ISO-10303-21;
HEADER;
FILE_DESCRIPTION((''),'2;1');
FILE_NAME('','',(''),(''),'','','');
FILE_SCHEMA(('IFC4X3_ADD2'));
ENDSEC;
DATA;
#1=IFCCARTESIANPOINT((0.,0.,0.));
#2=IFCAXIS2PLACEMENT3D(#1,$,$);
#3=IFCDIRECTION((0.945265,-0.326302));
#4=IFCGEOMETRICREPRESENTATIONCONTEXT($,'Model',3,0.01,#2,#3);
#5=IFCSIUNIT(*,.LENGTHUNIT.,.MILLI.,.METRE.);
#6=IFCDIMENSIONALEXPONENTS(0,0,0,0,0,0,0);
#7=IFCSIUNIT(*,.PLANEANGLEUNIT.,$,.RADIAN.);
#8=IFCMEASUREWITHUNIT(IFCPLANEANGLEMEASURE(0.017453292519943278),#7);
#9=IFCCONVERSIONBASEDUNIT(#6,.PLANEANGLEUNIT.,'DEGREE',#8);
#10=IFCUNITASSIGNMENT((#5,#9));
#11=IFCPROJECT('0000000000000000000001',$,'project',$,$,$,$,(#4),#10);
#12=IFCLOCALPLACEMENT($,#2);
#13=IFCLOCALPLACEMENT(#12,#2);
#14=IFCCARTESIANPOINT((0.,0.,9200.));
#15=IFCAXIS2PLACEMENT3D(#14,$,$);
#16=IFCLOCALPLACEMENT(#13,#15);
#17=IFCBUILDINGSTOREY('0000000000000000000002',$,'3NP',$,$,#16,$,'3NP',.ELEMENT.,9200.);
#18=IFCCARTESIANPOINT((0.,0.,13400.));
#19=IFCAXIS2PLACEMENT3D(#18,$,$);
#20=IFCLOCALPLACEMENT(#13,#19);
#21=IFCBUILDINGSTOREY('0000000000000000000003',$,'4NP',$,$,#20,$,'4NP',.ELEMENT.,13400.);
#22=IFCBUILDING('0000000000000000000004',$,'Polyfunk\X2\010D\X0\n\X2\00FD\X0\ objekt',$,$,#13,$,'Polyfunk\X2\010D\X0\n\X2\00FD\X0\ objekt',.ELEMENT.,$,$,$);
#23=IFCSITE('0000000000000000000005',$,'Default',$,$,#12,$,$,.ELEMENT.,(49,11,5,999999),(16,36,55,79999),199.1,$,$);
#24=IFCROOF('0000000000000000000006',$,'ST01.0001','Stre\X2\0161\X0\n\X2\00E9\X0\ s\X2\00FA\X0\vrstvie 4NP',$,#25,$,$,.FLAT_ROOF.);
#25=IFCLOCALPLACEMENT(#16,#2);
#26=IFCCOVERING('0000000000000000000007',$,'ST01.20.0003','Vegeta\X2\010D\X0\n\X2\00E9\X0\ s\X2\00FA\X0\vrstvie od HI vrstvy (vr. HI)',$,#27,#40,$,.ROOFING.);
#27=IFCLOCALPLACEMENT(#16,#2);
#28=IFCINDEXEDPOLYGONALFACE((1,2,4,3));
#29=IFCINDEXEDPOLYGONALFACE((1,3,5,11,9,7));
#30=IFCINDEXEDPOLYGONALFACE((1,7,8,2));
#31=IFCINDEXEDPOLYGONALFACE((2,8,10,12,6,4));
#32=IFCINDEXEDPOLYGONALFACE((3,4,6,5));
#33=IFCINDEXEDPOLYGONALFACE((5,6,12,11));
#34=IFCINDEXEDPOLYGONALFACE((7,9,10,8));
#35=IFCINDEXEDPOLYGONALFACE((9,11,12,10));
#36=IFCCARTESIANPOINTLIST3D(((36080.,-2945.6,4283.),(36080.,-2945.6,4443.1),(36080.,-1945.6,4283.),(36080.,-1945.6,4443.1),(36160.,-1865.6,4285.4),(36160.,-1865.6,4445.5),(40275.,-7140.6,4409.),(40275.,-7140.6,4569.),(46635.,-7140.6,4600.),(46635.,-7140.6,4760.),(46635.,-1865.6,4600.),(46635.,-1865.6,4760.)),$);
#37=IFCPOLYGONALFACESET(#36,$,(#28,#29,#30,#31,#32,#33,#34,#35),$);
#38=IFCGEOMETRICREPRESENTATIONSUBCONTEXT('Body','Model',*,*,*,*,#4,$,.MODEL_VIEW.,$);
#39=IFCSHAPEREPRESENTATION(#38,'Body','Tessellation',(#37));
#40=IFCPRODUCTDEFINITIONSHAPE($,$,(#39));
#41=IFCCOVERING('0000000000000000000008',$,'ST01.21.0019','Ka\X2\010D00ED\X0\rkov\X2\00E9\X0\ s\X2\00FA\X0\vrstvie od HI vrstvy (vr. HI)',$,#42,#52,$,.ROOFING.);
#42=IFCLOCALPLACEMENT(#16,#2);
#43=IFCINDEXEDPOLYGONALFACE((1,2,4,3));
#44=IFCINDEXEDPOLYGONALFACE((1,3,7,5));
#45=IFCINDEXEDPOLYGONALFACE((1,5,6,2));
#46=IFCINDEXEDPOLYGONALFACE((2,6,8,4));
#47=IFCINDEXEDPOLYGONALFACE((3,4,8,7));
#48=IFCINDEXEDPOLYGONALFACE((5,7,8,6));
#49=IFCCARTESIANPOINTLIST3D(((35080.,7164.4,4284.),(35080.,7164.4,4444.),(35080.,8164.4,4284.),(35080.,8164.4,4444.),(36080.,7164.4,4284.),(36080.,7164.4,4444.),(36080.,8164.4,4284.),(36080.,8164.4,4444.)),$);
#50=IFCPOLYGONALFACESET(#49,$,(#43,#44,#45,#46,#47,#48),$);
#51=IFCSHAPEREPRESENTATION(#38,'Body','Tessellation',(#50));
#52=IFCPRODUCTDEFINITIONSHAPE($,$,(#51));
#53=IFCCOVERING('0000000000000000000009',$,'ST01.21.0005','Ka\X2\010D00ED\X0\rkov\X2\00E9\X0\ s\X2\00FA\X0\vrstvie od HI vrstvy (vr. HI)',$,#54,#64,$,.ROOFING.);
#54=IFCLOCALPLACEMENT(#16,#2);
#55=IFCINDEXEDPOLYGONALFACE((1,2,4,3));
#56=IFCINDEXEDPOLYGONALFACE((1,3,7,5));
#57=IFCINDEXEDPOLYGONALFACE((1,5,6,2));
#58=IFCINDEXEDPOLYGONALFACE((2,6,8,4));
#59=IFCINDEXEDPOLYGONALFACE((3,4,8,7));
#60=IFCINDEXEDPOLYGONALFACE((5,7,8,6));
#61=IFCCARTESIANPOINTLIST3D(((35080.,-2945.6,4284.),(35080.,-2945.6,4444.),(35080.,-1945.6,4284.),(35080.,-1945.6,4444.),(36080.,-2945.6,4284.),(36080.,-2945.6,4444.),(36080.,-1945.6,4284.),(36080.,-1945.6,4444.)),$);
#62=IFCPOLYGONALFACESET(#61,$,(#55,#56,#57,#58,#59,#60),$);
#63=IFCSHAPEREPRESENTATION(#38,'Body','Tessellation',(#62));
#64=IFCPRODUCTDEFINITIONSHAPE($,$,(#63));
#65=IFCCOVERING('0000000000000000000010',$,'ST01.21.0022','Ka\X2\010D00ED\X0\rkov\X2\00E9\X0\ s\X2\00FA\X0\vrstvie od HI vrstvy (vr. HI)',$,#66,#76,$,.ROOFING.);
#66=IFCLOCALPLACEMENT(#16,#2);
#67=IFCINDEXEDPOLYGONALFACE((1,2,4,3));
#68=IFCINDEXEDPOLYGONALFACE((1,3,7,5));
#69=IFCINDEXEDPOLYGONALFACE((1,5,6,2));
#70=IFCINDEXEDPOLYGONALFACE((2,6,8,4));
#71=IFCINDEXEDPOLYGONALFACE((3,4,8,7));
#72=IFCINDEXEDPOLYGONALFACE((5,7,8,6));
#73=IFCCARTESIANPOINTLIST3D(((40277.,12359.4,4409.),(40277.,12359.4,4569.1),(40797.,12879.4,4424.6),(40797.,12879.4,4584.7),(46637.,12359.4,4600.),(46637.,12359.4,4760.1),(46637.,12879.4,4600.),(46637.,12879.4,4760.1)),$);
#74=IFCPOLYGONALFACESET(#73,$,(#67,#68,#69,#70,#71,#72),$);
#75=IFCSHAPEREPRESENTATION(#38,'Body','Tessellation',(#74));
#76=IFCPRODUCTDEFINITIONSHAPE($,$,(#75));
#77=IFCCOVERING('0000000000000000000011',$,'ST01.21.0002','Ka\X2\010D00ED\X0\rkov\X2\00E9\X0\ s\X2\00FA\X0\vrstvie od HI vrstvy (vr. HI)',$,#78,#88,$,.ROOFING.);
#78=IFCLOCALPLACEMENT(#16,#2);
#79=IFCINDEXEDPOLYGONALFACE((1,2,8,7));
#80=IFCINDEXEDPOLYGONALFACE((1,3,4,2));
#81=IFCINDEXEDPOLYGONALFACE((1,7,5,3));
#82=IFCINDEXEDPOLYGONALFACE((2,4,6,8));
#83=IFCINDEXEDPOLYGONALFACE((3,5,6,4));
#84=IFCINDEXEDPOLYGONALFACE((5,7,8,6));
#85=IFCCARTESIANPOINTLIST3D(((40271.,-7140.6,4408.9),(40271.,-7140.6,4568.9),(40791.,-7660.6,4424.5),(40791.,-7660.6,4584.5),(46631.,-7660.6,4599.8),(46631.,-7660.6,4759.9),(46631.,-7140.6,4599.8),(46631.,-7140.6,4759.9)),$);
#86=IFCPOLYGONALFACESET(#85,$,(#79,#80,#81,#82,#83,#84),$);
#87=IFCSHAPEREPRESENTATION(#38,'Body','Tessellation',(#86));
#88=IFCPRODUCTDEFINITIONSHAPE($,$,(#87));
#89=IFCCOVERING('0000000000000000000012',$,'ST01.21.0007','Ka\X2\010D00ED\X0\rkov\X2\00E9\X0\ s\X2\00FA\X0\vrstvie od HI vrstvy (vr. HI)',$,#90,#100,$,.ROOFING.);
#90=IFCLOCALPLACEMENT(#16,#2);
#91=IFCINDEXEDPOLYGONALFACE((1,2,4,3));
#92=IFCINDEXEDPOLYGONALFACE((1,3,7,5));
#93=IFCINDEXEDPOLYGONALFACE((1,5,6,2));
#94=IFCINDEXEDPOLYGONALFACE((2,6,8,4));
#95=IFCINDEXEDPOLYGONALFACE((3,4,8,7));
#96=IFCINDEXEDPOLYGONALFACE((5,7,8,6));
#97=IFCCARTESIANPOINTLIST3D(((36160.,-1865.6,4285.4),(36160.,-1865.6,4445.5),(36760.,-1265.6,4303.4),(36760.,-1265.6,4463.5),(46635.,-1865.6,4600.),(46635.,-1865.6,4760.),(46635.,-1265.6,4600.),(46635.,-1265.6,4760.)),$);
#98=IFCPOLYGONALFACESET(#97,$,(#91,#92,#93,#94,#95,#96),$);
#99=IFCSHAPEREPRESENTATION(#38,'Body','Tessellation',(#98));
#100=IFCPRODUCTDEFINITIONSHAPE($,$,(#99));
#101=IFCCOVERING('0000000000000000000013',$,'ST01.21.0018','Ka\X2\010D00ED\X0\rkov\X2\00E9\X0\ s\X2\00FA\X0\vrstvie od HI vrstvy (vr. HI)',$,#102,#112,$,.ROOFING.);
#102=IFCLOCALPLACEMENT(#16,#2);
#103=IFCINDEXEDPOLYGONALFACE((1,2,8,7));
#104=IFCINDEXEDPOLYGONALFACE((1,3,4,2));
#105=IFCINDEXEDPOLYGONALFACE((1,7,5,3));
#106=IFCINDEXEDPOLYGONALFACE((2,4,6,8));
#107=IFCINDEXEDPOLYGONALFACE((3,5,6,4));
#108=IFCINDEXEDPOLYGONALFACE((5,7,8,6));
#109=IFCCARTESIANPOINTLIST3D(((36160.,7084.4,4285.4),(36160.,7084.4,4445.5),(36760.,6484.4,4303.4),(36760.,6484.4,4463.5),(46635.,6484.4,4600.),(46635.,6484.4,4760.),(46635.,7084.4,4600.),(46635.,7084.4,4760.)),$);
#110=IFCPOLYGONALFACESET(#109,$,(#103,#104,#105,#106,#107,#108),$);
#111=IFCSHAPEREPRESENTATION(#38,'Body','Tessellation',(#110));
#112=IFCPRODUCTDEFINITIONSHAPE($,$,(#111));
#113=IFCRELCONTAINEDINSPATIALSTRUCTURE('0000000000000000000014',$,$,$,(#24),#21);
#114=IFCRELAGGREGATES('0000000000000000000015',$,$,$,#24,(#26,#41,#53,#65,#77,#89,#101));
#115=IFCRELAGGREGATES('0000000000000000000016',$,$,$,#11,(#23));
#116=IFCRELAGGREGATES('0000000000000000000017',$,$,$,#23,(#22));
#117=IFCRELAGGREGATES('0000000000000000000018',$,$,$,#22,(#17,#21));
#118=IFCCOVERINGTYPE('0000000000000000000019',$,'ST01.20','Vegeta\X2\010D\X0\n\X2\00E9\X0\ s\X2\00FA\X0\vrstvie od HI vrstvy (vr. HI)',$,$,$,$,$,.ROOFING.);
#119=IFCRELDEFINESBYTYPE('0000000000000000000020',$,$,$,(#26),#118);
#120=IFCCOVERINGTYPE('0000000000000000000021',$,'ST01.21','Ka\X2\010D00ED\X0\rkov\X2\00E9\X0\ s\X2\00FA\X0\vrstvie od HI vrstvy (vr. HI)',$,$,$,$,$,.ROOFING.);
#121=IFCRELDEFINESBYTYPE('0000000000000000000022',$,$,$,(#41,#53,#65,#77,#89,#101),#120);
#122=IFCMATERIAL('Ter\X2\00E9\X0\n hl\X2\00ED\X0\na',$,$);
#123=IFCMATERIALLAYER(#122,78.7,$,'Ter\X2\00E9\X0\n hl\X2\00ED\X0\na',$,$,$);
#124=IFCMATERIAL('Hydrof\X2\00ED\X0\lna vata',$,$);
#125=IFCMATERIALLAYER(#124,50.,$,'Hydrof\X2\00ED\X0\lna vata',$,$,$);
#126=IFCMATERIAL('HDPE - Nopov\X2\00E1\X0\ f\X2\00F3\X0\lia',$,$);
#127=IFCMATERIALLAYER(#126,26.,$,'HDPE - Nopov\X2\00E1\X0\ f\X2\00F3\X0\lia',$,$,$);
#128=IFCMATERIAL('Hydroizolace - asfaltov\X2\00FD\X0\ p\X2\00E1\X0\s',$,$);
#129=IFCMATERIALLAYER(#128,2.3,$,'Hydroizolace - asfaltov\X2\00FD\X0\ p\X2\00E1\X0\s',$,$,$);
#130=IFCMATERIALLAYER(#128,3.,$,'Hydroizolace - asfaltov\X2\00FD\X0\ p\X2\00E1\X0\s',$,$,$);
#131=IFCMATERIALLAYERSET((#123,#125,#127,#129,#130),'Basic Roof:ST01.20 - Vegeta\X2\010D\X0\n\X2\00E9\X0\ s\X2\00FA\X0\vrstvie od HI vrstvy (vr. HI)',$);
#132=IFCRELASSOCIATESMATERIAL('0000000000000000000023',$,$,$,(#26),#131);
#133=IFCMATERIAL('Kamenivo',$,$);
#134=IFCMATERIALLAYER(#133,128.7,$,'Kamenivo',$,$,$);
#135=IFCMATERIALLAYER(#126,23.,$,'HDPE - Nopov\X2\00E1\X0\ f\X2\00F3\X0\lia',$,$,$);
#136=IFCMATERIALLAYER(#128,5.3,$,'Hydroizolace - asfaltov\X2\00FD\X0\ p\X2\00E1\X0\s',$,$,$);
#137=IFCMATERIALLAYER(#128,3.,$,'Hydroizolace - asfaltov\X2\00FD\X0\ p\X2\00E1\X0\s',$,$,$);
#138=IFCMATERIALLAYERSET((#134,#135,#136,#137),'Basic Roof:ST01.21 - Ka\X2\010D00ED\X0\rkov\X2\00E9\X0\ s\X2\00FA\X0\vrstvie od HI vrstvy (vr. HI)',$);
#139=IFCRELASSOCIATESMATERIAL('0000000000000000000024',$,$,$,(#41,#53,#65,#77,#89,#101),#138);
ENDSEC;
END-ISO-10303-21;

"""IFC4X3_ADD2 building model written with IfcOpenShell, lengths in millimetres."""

from ifc_helpers import new_model, entity, si_unit, converted_unit, direction, frame, frame_2d, origin, origin_2d_with_axis, place, context, subcontext, project, spatial, polyline, rectangle, outline, extrude, material, layer, layer_set, type_object, element, aggregate, save


model = new_model("IFC4X3_ADD2")

# Units and contexts
model_context = context("Model", 3, precision=0.01, world=origin(), true_north=direction((0.945265, -0.326302)))
body_context = subcontext(model_context, "Body", "Model", "MODEL_VIEW")
ifc_project = project(units=[si_unit("LENGTHUNIT", "METRE", prefix="MILLI"), converted_unit("PLANEANGLEUNIT", "DEGREE", entity("IfcPlaneAngleMeasure", 0.017453292519943278), si_unit("PLANEANGLEUNIT", "RADIAN"), dimensions=[0, 0, 0, 0, 0, 0, 0])], contexts=[model_context])

# Site, building, storey
site_placement = place(None, origin())
site = spatial("IfcSite", under=ifc_project, at=site_placement, Name="Default", CompositionType="ELEMENT", RefLatitude=(49, 11, 5, 999999), RefLongitude=(16, 36, 55, 79999), RefElevation=199.1)
building_placement = place(site_placement, origin())
building = spatial("IfcBuilding", under=site, at=building_placement, Name="Polyfunkčný objekt", LongName="Polyfunkčný objekt", CompositionType="ELEMENT")
storey_1_placement = place(building_placement, frame((0.0, 0.0, 9200.0)))
storey_1 = spatial("IfcBuildingStorey", under=building, at=storey_1_placement, Name="3NP", LongName="3NP", CompositionType="ELEMENT", Elevation=9200.0)

# Shared definitions
storey_2_placement = place(building_placement, frame((0.0, 0.0, 13400.0)))
storey_2 = spatial("IfcBuildingStorey", under=building, at=storey_2_placement, Name="4NP", LongName="4NP", CompositionType="ELEMENT", Elevation=13400.0)

# Roof, coverings
roof = element("IfcRoof", 1, inside=storey_2, Name="ST01.0001", Description="Strešné súvrstvie 4NP", PredefinedType="FLAT_ROOF")
ifc_material_1 = material(Name="Hydroizolace - asfaltový pás")
ifc_material_2 = material(Name="Terén hlína")
ifc_layer_1 = layer(ifc_material_2, 78.7, Name="Terén hlína")
ifc_material_3 = material(Name="Hydrofílna vata")
ifc_layer_2 = layer(ifc_material_3, 50.0, Name="Hydrofílna vata")
ifc_material_4 = material(Name="HDPE - Nopová fólia")
ifc_layer_3 = layer(ifc_material_4, 26.0, Name="HDPE - Nopová fólia")
ifc_layer_4 = layer(ifc_material_1, 2.3, Name="Hydroizolace - asfaltový pás")
ifc_layer_5 = layer(ifc_material_1, 3.0, Name="Hydroizolace - asfaltový pás")
ifc_layer_set_1 = layer_set([ifc_layer_1, ifc_layer_2, ifc_layer_3, ifc_layer_4, ifc_layer_5], Name="Basic Roof:ST01.20 - Vegetačné súvrstvie od HI vrstvy (vr. HI)")
covering_type_1 = type_object("IfcCoveringType", Name="ST01.20", Description="Vegetačné súvrstvie od HI vrstvy (vr. HI)", PredefinedType="ROOFING")
placement_1 = place(storey_2_placement, frame((36080.0, -7140.6, 83.0)))
covering_1_placement = place(placement_1, origin())
covering_1 = element("IfcCovering", 2, at=covering_1_placement, type_object=covering_type_1, material=ifc_layer_set_1, Name="ST01.20.0003", Description="Vegetačné súvrstvie od HI vrstvy (vr. HI)", PredefinedType="ROOFING", context=body_context, shape_type="SweptSolid", body=[
    extrude(outline(polyline([(-5279.9, 1557.5), (-1083.0, -2637.5), (5279.9, -2637.5), (5279.9, 2637.5), (-5199.8, 2637.5), (-5279.9, 2557.5), (-5279.9, 1557.5)])), frame((5277.5, 2637.5, 158.5), z_axis=(-0.030015, 0.0, 0.999549), x_axis=(0.999549, 0.0, 0.030015)), (0.030015, 0.0, 0.999549), 160.1),
])
ifc_material_5 = material(Name="Kamenivo")
ifc_layer_6 = layer(ifc_material_5, 128.7, Name="Kamenivo")
ifc_layer_7 = layer(ifc_material_4, 23.0, Name="HDPE - Nopová fólia")
ifc_layer_8 = layer(ifc_material_1, 5.3, Name="Hydroizolace - asfaltový pás")
ifc_layer_9 = layer(ifc_material_1, 3.0, Name="Hydroizolace - asfaltový pás")
ifc_layer_set_2 = layer_set([ifc_layer_6, ifc_layer_7, ifc_layer_8, ifc_layer_9], Name="Basic Roof:ST01.21 - Kačírkové súvrstvie od HI vrstvy (vr. HI)")
covering_type_2 = type_object("IfcCoveringType", Name="ST01.21", Description="Kačírkové súvrstvie od HI vrstvy (vr. HI)", PredefinedType="ROOFING")
placement_2 = place(storey_2_placement, frame((35080.0, 7164.4, 84.0)))
covering_2_placement = place(placement_2, origin())
covering_2 = element("IfcCovering", 3, at=covering_2_placement, type_object=covering_type_2, material=ifc_layer_set_2, Name="ST01.21.0019", Description="Kačírkové súvrstvie od HI vrstvy (vr. HI)", PredefinedType="ROOFING", context=body_context, shape_type="SweptSolid", body=[
    extrude(rectangle(XDim=1000.0, YDim=1000.0, at=frame_2d((0.0, 0.0), x_axis=(1.0, 0.0))), frame((500.0, 500.0, 0.0)), (0.0, 0.0, 1.0), 160.0),
])
covering_3_placement = place(storey_2_placement, frame((35080.0, -2945.6, 84.0)))
covering_3 = element("IfcCovering", 4, at=covering_3_placement, type_object=covering_type_2, material=ifc_layer_set_2, Name="ST01.21.0005", Description="Kačírkové súvrstvie od HI vrstvy (vr. HI)", PredefinedType="ROOFING", context=body_context, shape_type="SweptSolid", body=[
    extrude(rectangle(XDim=1000.0, YDim=1000.0, at=origin_2d_with_axis()), frame((500.0, 500.0, 0.0), z_axis=(0.0, 0.0, 1.0), x_axis=(0.0, -1.0, 0.0)), (0.0, 0.0, 1.0), 160.0),
])
placement_3 = place(storey_2_placement, frame((40277.0, 12359.4, 209.0)))
covering_4_placement = place(placement_3, origin())
covering_4 = element("IfcCovering", 5, at=covering_4_placement, type_object=covering_type_2, material=ifc_layer_set_2, Name="ST01.21.0022", Description="Kačírkové súvrstvie od HI vrstvy (vr. HI)", PredefinedType="ROOFING", context=body_context, shape_type="SweptSolid", body=[
    extrude(outline(polyline([(-3181.4, -260.0), (3181.4, -260.0), (3181.4, 260.0), (-2661.2, 260.0), (-3181.4, -260.0)])), frame((3180.0, 260.0, 95.5), z_axis=(-0.030015, 0.0, 0.999549), x_axis=(0.999549, 0.0, 0.030015)), (0.030015, 0.0, 0.999549), 160.1),
])
placement_4 = place(storey_2_placement, frame((40271.0, -7660.6, 208.9)))
covering_5_placement = place(placement_4, origin())
covering_5 = element("IfcCovering", 6, at=covering_5_placement, type_object=covering_type_2, material=ifc_layer_set_2, Name="ST01.21.0002", Description="Kačírkové súvrstvie od HI vrstvy (vr. HI)", PredefinedType="ROOFING", context=body_context, shape_type="SweptSolid", body=[
    extrude(outline(polyline([(-2661.2, -260.0), (3181.4, -260.0), (3181.4, 260.0), (-3181.4, 260.0), (-2661.2, -260.0)])), frame((3180.0, 260.0, 95.5), z_axis=(-0.030015, 0.0, 0.999549), x_axis=(0.999549, 0.0, 0.030015)), (0.030015, 0.0, 0.999549), 160.1),
])
placement_5 = place(storey_2_placement, frame((36160.0, -1865.6, 85.4)))
covering_6_placement = place(placement_5, origin())
covering_6 = element("IfcCovering", 7, at=covering_6_placement, type_object=covering_type_2, material=ifc_layer_set_2, Name="ST01.21.0007", Description="Kačírkové súvrstvie od HI vrstvy (vr. HI)", PredefinedType="ROOFING", context=body_context, shape_type="SweptSolid", body=[
    extrude(outline(polyline([(-5239.9, -300.0), (5239.9, -300.0), (5239.9, 300.0), (-4639.6, 300.0), (-5239.9, -300.0)])), frame((5237.5, 300.0, 157.3), z_axis=(-0.030015, 0.0, 0.999549), x_axis=(0.999549, 0.0, 0.030015)), (0.030015, 0.0, 0.999549), 160.1),
])
placement_6 = place(storey_2_placement, frame((36160.0, 6484.4, 85.4)))
covering_7_placement = place(placement_6, origin())
covering_7 = element("IfcCovering", 8, at=covering_7_placement, type_object=covering_type_2, material=ifc_layer_set_2, Name="ST01.21.0018", Description="Kačírkové súvrstvie od HI vrstvy (vr. HI)", PredefinedType="ROOFING", context=body_context, shape_type="SweptSolid", body=[
    extrude(outline(polyline([(-4639.6, -300.0), (5239.9, -300.0), (5239.9, 300.0), (-5239.9, 300.0), (-4639.6, -300.0)])), frame((5237.5, 300.0, 157.3), z_axis=(-0.030015, 0.0, 0.999549), x_axis=(0.999549, 0.0, 0.030015)), (0.030015, 0.0, 0.999549), 160.1),
])
aggregate(roof, [covering_1, covering_2, covering_3, covering_4, covering_5, covering_6, covering_7])

save(model, "model.ifc")
